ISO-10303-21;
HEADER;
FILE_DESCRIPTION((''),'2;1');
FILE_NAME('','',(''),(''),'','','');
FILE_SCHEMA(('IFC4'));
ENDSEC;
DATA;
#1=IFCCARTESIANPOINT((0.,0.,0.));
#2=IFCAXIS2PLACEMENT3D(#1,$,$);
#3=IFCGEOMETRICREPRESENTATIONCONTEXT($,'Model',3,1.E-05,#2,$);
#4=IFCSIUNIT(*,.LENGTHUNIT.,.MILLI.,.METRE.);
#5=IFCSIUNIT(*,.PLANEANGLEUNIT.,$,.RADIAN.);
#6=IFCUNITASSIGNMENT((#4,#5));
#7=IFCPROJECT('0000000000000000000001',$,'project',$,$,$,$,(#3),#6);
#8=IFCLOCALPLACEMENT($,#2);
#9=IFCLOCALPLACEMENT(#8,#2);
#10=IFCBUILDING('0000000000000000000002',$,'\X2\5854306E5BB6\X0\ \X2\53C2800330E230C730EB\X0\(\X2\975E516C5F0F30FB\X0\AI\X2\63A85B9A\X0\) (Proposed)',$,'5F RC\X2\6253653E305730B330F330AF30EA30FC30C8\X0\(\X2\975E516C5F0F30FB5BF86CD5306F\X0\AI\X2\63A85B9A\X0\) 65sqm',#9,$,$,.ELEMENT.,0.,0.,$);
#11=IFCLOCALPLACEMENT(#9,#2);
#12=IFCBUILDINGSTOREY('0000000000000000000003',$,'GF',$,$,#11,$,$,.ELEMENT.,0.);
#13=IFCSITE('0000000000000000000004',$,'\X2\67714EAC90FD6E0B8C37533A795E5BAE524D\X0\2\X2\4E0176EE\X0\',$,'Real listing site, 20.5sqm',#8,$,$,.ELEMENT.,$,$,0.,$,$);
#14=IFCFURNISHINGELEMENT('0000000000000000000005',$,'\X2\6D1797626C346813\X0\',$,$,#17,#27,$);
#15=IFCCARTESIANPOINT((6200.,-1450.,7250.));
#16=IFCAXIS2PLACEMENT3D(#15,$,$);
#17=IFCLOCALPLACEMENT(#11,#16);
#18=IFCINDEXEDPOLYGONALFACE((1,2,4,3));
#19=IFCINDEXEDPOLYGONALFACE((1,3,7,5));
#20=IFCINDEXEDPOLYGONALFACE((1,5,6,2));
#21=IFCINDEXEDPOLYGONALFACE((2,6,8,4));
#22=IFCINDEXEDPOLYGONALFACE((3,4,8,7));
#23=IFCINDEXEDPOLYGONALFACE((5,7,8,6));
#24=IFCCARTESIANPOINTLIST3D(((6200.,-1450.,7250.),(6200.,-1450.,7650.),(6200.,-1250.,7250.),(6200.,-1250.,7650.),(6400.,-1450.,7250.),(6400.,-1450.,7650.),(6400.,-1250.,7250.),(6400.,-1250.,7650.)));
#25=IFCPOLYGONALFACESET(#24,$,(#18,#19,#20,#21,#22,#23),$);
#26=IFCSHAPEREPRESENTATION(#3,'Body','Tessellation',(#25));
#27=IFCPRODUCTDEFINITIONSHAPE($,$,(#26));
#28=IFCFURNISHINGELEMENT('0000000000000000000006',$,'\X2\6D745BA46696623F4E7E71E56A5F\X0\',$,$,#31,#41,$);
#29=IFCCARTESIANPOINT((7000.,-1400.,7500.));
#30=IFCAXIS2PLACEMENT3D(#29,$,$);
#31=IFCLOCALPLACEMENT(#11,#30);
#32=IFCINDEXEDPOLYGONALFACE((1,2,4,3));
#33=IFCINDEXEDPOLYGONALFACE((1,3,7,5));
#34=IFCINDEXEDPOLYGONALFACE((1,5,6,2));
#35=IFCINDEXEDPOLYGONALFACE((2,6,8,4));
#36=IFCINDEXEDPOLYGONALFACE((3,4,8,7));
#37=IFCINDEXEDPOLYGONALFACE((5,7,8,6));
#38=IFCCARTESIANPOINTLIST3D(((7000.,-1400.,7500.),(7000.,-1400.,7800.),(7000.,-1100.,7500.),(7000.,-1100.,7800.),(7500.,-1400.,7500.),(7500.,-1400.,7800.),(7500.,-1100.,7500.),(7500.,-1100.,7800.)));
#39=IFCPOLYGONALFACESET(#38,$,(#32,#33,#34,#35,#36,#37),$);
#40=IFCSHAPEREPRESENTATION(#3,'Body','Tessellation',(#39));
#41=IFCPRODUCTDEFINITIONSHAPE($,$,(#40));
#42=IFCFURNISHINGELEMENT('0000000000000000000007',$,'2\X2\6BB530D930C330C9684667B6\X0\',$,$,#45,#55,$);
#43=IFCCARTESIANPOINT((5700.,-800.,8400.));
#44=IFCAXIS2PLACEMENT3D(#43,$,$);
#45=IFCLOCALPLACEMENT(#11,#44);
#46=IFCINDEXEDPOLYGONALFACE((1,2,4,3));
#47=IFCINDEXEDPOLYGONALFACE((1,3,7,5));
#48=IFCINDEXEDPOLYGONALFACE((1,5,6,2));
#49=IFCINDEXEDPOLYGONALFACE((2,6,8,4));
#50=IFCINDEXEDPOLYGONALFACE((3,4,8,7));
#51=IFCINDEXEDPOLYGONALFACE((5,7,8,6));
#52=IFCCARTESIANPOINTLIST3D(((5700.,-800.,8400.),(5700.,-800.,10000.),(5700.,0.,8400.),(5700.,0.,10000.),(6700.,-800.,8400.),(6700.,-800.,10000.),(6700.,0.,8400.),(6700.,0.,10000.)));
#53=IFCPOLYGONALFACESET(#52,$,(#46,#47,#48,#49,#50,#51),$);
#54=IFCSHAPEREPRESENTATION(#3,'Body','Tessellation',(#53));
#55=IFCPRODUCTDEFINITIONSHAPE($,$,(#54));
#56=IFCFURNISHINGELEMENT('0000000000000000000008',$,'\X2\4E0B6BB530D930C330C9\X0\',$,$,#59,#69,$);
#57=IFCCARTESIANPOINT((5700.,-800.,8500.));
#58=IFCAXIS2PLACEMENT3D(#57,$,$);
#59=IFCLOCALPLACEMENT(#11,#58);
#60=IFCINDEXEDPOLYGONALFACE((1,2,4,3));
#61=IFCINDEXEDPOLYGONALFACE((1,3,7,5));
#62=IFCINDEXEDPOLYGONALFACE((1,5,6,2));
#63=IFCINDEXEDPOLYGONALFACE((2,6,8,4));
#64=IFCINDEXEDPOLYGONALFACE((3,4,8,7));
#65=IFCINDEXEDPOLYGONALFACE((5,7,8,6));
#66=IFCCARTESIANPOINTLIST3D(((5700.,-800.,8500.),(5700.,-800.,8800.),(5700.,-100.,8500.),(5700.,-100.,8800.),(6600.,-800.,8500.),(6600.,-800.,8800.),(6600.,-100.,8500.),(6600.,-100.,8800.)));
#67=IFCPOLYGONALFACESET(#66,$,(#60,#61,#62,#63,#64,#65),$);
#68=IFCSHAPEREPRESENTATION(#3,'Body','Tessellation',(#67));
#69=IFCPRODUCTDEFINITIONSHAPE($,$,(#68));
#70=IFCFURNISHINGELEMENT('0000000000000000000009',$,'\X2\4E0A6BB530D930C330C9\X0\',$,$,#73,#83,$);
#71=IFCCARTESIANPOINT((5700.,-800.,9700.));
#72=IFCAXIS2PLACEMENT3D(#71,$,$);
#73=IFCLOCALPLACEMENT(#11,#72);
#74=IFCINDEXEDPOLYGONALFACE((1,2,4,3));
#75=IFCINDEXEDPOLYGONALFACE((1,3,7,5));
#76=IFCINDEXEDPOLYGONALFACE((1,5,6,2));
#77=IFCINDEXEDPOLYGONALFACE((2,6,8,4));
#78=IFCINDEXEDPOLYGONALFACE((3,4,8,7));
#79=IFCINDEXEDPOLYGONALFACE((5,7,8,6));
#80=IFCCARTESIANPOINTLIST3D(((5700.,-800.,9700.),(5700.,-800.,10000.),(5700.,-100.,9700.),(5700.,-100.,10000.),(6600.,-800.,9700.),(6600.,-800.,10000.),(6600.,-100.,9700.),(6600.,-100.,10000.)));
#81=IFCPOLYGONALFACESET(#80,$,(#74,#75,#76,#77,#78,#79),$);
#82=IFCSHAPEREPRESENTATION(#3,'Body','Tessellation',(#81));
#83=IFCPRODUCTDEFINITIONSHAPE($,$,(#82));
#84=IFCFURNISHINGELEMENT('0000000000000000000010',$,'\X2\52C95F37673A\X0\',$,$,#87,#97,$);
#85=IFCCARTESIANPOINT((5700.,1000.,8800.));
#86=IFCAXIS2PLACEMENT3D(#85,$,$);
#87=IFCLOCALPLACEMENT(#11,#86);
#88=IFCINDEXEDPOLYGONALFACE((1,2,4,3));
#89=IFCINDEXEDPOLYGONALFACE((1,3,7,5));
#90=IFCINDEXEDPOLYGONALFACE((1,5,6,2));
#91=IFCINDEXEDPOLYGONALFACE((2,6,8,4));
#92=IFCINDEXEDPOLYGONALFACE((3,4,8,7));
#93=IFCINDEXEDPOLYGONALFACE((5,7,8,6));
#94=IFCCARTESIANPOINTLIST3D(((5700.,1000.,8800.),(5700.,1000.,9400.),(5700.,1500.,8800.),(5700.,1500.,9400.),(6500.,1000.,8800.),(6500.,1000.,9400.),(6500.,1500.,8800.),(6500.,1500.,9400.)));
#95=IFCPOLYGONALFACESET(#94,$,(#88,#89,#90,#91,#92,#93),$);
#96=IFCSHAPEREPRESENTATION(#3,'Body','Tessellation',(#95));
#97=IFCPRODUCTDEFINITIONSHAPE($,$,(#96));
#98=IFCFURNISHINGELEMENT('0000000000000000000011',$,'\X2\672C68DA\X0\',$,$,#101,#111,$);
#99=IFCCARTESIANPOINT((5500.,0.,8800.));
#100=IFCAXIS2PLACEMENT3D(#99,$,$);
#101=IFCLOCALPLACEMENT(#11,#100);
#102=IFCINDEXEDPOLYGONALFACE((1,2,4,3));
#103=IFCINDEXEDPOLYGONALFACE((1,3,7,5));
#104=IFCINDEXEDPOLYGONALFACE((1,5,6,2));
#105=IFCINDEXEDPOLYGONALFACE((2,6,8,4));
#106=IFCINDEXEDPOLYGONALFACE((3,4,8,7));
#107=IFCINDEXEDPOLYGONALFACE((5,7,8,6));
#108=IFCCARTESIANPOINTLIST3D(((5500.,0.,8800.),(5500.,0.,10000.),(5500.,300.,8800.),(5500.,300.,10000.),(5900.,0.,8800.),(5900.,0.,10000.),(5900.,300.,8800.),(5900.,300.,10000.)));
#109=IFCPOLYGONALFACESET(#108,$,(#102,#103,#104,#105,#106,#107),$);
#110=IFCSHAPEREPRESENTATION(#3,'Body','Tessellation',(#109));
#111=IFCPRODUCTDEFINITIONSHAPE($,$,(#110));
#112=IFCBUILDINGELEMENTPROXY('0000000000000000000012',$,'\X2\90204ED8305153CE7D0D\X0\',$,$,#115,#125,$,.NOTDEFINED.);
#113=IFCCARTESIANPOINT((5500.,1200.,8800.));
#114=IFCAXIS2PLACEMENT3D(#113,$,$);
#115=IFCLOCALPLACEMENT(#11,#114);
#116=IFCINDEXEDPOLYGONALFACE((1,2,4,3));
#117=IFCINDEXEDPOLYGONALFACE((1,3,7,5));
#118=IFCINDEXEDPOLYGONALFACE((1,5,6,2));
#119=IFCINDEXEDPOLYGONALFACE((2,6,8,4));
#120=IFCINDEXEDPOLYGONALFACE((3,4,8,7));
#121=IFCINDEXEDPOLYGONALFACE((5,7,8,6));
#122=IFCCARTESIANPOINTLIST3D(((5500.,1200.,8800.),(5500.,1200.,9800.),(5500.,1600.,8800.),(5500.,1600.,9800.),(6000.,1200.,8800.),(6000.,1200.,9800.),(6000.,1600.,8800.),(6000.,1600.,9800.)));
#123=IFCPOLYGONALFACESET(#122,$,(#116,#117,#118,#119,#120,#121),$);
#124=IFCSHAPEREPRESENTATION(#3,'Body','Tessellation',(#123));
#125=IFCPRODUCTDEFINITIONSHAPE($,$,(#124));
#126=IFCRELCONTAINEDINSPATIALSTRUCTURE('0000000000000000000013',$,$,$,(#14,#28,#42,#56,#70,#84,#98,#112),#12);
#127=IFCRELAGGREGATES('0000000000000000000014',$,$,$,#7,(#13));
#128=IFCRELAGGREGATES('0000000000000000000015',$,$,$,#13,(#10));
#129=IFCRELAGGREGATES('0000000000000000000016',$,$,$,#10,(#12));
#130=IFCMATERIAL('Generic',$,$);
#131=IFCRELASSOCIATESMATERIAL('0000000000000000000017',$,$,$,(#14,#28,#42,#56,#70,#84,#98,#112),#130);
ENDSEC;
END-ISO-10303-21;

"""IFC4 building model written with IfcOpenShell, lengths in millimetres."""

from ifc_helpers import new_model, si_unit, frame, frame_2d, origin, place, context, project, spatial, rectangle, extrude, material, element, save


model = new_model("IFC4")

# Units and contexts
model_context = context("Model", 3, precision=1e-05, world=origin())
ifc_project = project(units=[si_unit("LENGTHUNIT", "METRE", prefix="MILLI"), si_unit("PLANEANGLEUNIT", "RADIAN")], contexts=[model_context])

# Site, building, storey
site_placement = place(None, origin())
site = spatial("IfcSite", under=ifc_project, at=site_placement, Name="東京都渋谷区神宮前2丁目", ObjectType="Real listing site, 20.5sqm", CompositionType="ELEMENT", RefElevation=0.0)
building_placement = place(site_placement, origin())
building = spatial("IfcBuilding", under=site, at=building_placement, Name="塔の家 参考モデル(非公式・AI推定) (Proposed)", ObjectType="5F RC打放しコンクリート(非公式・寸法はAI推定) 65sqm", CompositionType="ELEMENT", ElevationOfRefHeight=0.0, ElevationOfTerrain=0.0)
storey_placement = place(building_placement, origin())
storey = spatial("IfcBuildingStorey", under=building, at=storey_placement, Name="GF", CompositionType="ELEMENT", Elevation=0.0)

# Shared definitions
ifc_material = material(Name="Generic")

# Furnishing elements
furnishing_1_placement = place(storey_placement, frame((6200.0, -1450.0, 7250.0)))
element("IfcFurnishingElement", 1, at=furnishing_1_placement, inside=storey, material=ifc_material, Name="洗面水栓", context=model_context, shape_type="SweptSolid", body=[
    extrude(rectangle(XDim=200.0, YDim=200.0, at=frame_2d((100.0, 100.0))), frame((6200.0, -1450.0, 7250.0)), (0.0, 0.0, 1.0), 400.0),
])
furnishing_2_placement = place(storey_placement, frame((7000.0, -1400.0, 7500.0)))
element("IfcFurnishingElement", 2, at=furnishing_2_placement, inside=storey, material=ifc_material, Name="浴室暖房乾燥機", context=model_context, shape_type="SweptSolid", body=[
    extrude(rectangle(XDim=500.0, YDim=300.0, at=frame_2d((250.0, 150.0))), frame((7000.0, -1400.0, 7500.0)), (0.0, 0.0, 1.0), 300.0),
])
furnishing_3_placement = place(storey_placement, frame((5700.0, -800.0, 8400.0)))
element("IfcFurnishingElement", 3, at=furnishing_3_placement, inside=storey, material=ifc_material, Name="2段ベッド框架", context=model_context, shape_type="SweptSolid", body=[
    extrude(rectangle(XDim=1000.0, YDim=800.0, at=frame_2d((500.0, 400.0))), frame((5700.0, -800.0, 8400.0)), (0.0, 0.0, 1.0), 1600.0),
])
furnishing_4_placement = place(storey_placement, frame((5700.0, -800.0, 8500.0)))
element("IfcFurnishingElement", 4, at=furnishing_4_placement, inside=storey, material=ifc_material, Name="下段ベッド", context=model_context, shape_type="SweptSolid", body=[
    extrude(rectangle(XDim=900.0, YDim=700.0, at=frame_2d((450.0, 350.0))), frame((5700.0, -800.0, 8500.0)), (0.0, 0.0, 1.0), 300.0),
])
furnishing_5_placement = place(storey_placement, frame((5700.0, -800.0, 9700.0)))
element("IfcFurnishingElement", 5, at=furnishing_5_placement, inside=storey, material=ifc_material, Name="上段ベッド", context=model_context, shape_type="SweptSolid", body=[
    extrude(rectangle(XDim=900.0, YDim=700.0, at=frame_2d((450.0, 350.0))), frame((5700.0, -800.0, 9700.0)), (0.0, 0.0, 1.0), 300.0),
])
furnishing_6_placement = place(storey_placement, frame((5700.0, 1000.0, 8800.0)))
element("IfcFurnishingElement", 6, at=furnishing_6_placement, inside=storey, material=ifc_material, Name="勉強机", context=model_context, shape_type="SweptSolid", body=[
    extrude(rectangle(XDim=800.0, YDim=500.0, at=frame_2d((400.0, 250.0))), frame((5700.0, 1000.0, 8800.0)), (0.0, 0.0, 1.0), 600.0),
])
furnishing_7_placement = place(storey_placement, frame((5500.0, 0.0, 8800.0)))
element("IfcFurnishingElement", 7, at=furnishing_7_placement, inside=storey, material=ifc_material, Name="本棚", context=model_context, shape_type="SweptSolid", body=[
    extrude(rectangle(XDim=400.0, YDim=300.0, at=frame_2d((200.0, 150.0))), frame((5500.0, 0.0, 8800.0)), (0.0, 0.0, 1.0), 1200.0),
])

# Building element proxy
proxy_placement = place(storey_placement, frame((5500.0, 1200.0, 8800.0)))
element("IfcBuildingElementProxy", 8, at=proxy_placement, inside=storey, material=ifc_material, Name="造付け収納", PredefinedType="NOTDEFINED", context=model_context, shape_type="SweptSolid", body=[
    extrude(rectangle(XDim=500.0, YDim=400.0, at=frame_2d((250.0, 200.0))), frame((5500.0, 1200.0, 8800.0)), (0.0, 0.0, 1.0), 1000.0),
])

save(model, "model.ifc")
